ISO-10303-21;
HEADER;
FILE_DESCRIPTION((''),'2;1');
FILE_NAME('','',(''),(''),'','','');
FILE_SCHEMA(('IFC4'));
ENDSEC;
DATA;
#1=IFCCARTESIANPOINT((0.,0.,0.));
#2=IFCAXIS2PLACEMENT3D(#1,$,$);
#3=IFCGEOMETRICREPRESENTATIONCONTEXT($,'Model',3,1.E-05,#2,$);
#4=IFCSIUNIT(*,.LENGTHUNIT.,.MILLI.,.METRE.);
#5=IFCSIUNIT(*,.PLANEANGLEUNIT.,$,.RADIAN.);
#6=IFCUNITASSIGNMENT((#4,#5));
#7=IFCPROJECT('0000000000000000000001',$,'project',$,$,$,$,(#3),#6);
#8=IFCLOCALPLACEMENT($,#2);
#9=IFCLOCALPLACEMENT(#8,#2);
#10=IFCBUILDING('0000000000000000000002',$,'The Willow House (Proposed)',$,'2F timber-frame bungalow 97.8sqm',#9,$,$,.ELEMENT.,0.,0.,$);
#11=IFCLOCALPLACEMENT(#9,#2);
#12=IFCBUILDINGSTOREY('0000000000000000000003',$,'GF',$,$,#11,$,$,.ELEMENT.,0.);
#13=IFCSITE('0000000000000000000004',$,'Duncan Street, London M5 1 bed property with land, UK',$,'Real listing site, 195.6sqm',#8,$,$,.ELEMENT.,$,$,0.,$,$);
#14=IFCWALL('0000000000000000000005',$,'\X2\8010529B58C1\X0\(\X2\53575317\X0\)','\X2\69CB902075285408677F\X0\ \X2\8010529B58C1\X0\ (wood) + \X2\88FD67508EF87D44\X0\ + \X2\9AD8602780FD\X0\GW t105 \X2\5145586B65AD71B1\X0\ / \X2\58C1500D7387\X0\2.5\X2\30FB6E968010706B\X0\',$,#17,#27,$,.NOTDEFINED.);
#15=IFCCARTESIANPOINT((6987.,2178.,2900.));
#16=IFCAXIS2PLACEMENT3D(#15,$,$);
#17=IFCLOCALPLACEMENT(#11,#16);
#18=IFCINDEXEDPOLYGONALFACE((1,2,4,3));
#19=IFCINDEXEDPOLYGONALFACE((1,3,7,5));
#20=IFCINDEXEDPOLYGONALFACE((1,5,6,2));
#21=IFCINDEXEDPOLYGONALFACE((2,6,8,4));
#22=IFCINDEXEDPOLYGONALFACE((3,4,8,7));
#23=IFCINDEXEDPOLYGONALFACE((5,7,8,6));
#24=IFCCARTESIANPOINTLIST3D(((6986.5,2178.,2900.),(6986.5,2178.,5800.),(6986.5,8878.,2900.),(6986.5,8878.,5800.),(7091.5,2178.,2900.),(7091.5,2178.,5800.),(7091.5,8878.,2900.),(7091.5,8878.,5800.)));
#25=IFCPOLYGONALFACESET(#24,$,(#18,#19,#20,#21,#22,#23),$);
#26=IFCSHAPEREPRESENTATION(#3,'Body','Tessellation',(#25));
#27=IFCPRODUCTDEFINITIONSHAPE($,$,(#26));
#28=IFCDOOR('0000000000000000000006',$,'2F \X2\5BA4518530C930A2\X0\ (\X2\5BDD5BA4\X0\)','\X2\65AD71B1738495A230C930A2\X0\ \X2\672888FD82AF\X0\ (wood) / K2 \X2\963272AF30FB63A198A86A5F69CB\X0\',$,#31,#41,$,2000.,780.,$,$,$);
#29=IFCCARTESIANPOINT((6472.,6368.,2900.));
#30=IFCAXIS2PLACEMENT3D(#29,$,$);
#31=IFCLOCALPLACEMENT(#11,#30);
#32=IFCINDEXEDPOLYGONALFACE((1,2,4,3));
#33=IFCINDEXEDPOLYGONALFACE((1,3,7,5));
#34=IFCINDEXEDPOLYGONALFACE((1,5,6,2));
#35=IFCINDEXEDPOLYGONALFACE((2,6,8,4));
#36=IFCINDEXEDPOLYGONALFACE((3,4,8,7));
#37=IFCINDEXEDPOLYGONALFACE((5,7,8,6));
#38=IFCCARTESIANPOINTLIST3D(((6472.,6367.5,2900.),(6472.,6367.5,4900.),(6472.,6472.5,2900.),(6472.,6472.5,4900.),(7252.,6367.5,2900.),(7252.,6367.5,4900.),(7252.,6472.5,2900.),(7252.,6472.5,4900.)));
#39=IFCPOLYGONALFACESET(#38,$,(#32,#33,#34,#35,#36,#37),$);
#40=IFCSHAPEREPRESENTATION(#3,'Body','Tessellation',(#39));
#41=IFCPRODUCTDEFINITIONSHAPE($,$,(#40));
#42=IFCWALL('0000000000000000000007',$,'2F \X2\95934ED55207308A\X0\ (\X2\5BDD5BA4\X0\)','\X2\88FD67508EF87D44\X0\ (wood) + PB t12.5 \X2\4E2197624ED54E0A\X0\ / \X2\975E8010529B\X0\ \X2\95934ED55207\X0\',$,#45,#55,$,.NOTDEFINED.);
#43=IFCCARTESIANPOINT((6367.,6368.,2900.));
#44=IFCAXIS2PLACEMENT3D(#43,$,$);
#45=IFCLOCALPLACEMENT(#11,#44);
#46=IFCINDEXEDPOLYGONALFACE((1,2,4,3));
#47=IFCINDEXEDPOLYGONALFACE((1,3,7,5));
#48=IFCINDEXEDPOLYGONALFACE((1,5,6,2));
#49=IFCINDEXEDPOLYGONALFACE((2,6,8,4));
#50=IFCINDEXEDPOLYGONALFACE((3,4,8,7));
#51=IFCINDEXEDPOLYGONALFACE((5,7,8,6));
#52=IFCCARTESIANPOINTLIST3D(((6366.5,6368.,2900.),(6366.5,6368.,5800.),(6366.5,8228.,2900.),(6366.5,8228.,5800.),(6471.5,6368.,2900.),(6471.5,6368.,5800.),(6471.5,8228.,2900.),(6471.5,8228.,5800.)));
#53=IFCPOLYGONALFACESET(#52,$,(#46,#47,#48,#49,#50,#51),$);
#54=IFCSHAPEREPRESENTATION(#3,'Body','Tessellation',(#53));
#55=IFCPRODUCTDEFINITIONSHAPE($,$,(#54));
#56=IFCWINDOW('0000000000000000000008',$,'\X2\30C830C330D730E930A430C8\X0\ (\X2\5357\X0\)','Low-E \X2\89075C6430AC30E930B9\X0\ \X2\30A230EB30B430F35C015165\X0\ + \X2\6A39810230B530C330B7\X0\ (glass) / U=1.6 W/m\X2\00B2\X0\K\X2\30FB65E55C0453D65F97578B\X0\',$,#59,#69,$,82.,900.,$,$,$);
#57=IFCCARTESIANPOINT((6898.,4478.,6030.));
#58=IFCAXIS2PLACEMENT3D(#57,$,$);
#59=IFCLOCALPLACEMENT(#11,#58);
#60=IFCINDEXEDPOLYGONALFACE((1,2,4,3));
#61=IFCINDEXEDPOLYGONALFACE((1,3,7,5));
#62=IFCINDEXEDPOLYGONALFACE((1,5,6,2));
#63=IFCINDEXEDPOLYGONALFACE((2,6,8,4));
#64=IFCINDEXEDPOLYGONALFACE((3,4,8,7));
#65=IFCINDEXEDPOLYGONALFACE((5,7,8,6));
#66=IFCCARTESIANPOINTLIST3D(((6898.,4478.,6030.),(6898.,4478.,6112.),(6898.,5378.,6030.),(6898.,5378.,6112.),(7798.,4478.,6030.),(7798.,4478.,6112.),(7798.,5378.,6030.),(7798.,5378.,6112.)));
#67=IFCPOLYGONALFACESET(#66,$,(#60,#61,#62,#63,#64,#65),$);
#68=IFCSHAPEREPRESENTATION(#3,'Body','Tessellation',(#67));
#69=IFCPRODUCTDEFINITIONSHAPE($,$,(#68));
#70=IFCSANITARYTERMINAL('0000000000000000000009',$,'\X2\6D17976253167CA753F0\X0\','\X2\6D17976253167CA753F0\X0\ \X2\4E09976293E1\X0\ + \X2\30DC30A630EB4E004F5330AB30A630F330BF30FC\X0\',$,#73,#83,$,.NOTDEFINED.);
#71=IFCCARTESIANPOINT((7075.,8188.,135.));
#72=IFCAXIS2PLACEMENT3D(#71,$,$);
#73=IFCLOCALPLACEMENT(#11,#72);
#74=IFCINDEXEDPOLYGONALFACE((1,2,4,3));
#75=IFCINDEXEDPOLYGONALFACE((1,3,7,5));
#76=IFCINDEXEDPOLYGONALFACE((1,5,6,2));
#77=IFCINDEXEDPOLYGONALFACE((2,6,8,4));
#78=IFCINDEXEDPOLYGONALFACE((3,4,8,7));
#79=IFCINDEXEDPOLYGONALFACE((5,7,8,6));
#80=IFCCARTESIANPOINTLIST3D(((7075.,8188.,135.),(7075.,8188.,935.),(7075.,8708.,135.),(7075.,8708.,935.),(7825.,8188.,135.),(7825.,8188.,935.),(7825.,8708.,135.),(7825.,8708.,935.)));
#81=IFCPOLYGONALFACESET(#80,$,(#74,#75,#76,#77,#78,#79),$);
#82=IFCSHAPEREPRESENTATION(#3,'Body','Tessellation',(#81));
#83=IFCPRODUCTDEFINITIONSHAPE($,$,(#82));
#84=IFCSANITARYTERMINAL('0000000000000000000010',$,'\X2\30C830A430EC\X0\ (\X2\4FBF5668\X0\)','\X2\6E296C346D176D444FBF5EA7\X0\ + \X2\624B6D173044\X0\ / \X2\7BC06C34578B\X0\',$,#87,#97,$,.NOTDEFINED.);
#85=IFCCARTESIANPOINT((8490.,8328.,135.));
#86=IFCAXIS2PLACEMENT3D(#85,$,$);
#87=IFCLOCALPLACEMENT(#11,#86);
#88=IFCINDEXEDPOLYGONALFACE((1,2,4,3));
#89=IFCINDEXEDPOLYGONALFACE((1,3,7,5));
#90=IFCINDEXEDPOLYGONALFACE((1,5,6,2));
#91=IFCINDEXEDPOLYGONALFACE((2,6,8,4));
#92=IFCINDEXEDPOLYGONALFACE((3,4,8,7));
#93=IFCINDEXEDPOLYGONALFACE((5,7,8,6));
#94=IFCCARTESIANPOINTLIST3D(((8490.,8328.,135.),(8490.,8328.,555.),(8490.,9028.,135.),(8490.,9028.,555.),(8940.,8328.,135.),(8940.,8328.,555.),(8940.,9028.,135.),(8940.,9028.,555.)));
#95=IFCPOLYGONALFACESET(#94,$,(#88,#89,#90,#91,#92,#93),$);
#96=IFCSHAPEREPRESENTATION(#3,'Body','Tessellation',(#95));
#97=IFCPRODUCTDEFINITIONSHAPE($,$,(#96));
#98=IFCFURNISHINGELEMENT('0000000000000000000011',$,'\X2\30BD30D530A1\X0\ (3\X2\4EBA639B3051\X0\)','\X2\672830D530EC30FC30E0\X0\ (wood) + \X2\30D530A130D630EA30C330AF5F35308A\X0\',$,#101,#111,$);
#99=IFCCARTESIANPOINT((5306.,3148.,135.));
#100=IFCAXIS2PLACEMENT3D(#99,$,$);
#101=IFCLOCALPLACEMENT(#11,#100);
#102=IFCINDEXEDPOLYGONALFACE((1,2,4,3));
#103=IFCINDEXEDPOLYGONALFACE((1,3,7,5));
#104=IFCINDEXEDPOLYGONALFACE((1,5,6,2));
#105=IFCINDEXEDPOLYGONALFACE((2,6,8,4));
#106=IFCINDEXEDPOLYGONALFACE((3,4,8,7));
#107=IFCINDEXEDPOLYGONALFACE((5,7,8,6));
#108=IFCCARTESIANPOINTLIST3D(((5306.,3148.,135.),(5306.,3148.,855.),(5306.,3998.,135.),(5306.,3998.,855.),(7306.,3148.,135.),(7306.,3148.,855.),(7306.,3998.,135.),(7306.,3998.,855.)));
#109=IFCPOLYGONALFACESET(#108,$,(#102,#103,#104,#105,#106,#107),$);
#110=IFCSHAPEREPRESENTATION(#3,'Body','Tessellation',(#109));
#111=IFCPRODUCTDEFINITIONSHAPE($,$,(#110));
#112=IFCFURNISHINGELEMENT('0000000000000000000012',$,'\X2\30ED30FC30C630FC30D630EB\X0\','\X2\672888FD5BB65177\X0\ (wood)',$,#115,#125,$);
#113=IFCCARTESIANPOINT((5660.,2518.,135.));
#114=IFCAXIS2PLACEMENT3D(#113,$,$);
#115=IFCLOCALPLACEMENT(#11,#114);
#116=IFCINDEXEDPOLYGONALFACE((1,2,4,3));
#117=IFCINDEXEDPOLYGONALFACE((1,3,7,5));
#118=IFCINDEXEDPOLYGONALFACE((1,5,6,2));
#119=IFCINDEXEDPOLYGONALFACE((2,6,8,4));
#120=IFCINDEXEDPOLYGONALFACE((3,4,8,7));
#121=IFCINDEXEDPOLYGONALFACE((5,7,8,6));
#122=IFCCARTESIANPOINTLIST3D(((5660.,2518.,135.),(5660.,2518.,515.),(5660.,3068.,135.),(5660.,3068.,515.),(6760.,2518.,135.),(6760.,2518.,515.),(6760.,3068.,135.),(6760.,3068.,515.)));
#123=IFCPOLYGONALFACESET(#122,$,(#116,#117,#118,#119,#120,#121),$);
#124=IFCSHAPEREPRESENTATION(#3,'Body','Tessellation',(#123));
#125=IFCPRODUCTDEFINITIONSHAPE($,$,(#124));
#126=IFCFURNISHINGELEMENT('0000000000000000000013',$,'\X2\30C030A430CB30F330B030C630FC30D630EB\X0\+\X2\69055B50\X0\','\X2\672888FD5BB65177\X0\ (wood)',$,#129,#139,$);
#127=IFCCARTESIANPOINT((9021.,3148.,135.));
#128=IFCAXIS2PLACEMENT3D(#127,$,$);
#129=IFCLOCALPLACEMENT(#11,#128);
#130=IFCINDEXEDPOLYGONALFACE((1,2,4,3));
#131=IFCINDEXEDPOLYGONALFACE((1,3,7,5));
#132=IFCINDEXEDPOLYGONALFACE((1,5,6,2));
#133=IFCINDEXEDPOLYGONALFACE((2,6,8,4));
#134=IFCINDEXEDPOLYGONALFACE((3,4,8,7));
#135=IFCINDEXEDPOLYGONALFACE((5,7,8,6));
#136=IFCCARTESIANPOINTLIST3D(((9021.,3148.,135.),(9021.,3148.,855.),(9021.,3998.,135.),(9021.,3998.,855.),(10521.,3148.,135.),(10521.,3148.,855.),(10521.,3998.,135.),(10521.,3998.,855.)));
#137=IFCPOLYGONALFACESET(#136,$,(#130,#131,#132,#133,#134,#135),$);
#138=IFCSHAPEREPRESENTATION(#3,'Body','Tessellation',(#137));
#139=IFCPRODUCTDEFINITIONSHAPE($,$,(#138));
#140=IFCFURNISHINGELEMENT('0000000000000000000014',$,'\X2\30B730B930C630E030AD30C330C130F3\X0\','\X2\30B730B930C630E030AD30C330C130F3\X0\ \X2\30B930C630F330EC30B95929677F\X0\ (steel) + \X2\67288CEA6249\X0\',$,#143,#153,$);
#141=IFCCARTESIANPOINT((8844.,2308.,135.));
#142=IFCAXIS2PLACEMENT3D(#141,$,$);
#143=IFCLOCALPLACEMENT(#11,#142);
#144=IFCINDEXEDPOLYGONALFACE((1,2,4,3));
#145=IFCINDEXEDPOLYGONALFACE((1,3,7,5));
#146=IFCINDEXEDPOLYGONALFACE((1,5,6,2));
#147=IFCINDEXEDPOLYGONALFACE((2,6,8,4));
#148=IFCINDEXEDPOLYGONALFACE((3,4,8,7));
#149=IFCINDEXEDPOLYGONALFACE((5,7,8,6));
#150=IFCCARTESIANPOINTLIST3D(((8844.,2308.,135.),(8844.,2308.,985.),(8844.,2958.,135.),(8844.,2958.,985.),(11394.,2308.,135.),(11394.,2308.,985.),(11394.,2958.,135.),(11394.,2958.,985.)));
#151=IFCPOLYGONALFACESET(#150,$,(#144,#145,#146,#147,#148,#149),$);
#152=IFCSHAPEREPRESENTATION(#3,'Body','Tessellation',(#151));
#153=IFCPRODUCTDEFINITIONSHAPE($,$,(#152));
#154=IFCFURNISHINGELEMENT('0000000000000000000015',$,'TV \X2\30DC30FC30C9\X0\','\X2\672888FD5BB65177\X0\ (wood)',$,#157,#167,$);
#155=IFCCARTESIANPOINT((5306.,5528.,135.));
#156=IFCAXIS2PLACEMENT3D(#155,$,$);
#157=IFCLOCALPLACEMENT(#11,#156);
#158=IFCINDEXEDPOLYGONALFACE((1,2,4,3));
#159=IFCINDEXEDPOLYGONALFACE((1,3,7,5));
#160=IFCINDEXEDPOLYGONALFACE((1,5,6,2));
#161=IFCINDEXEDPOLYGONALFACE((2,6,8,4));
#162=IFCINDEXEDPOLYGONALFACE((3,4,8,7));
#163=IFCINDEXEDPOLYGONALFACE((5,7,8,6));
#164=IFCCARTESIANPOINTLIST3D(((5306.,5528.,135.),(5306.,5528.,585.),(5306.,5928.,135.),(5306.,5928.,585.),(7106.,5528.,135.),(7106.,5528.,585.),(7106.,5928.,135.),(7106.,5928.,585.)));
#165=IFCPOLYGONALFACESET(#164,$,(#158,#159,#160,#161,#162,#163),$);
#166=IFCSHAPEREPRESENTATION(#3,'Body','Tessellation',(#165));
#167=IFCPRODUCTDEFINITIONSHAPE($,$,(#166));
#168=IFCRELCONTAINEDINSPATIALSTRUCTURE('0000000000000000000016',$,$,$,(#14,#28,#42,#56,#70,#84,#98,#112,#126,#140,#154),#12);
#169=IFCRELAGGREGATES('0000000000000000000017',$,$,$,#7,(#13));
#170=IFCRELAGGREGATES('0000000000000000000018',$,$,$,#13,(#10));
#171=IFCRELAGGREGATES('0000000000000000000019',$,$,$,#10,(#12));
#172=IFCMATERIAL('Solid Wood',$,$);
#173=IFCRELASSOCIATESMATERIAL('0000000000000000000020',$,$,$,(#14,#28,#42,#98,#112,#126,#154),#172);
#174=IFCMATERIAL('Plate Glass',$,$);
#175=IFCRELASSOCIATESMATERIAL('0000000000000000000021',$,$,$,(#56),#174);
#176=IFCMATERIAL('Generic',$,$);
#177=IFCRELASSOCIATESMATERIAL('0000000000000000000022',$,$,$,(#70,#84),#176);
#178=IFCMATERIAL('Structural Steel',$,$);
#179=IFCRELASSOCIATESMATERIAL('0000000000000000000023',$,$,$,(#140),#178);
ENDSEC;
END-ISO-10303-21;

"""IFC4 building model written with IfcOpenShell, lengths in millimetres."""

from ifc_helpers import new_model, si_unit, frame, frame_2d, origin, place, context, project, spatial, rectangle, extrude, material, element, fill, save


model = new_model("IFC4")

# Units and contexts
model_context = context("Model", 3, precision=1e-05, world=origin())
ifc_project = project(units=[si_unit("LENGTHUNIT", "METRE", prefix="MILLI"), si_unit("PLANEANGLEUNIT", "RADIAN")], contexts=[model_context])

# Site, building, storey
site_placement = place(None, origin())
site = spatial("IfcSite", under=ifc_project, at=site_placement, Name="Duncan Street, London M5 1 bed property with land, UK", ObjectType="Real listing site, 195.6sqm", CompositionType="ELEMENT", RefElevation=0.0)
building_placement = place(site_placement, origin())
building = spatial("IfcBuilding", under=site, at=building_placement, Name="The Willow House (Proposed)", ObjectType="2F timber-frame bungalow 97.8sqm", CompositionType="ELEMENT", ElevationOfRefHeight=0.0, ElevationOfTerrain=0.0)
storey_placement = place(building_placement, origin())
storey = spatial("IfcBuildingStorey", under=building, at=storey_placement, Name="GF", CompositionType="ELEMENT", Elevation=0.0)

# Shared definitions
ifc_material_1 = material(Name="Solid Wood")

# Wall, opening, door
wall_1_placement = place(storey_placement, frame((6987.0, 2178.0, 2900.0)))
wall_1 = element("IfcWall", 1, at=wall_1_placement, inside=storey, material=ifc_material_1, Name="耐力壁(南北)", Description="構造用合板 耐力壁 (wood) + 製材軸組 + 高性能GW t105 充填断熱 / 壁倍率2.5・準耐火", PredefinedType="NOTDEFINED", context=model_context, shape_type="SweptSolid", body=[
    extrude(rectangle(XDim=105.0, YDim=6700.0, at=frame_2d((52.0, 3350.0))), frame((6987.0, 2178.0, 2900.0)), (0.0, 0.0, 1.0), 2900.0),
])
opening_1_placement = place(storey_placement, frame((6472.0, 6368.0, 2900.0)))
opening_1 = element("IfcOpeningElement", 2, at=opening_1_placement, cuts=wall_1, PredefinedType="NOTDEFINED", context=model_context, shape_type="SweptSolid", body=[
    extrude(rectangle(XDim=780.0, YDim=105.0, at=frame_2d((390.0, 52.0))), frame((6472.0, 6368.0, 2900.0)), (0.0, 0.0, 1.0), 2000.0),
])
door_1_placement = place(storey_placement, frame((6472.0, 6368.0, 2900.0)))
door_1 = element("IfcDoor", 3, at=door_1_placement, inside=storey, material=ifc_material_1, Name="2F 室内ドア (寝室)", Description="断熱玄関ドア 木製芯 (wood) / K2 防犯・採風機構", OverallHeight=2000.0, OverallWidth=780.0, context=model_context, shape_type="SweptSolid", body=[
    extrude(rectangle(XDim=780.0, YDim=105.0, at=frame_2d((390.0, 52.0))), frame((6472.0, 6368.0, 2900.0)), (0.0, 0.0, 1.0), 2000.0),
])
fill(opening_1, door_1)

# Wall
wall_2_placement = place(storey_placement, frame((6367.0, 6368.0, 2900.0)))
element("IfcWall", 4, at=wall_2_placement, inside=storey, material=ifc_material_1, Name="2F 間仕切り (寝室)", Description="製材軸組 (wood) + PB t12.5 両面仕上 / 非耐力 間仕切", PredefinedType="NOTDEFINED", context=model_context, shape_type="SweptSolid", body=[
    extrude(rectangle(XDim=105.0, YDim=1860.0, at=frame_2d((52.0, 930.0))), frame((6367.0, 6368.0, 2900.0)), (0.0, 0.0, 1.0), 2900.0),
])

# Window
ifc_material_2 = material(Name="Plate Glass")
window_placement = place(storey_placement, frame((6898.0, 4478.0, 6030.0)))
element("IfcWindow", 5, at=window_placement, inside=storey, material=ifc_material_2, Name="トップライト (南)", Description="Low-E 複層ガラス アルゴン封入 + 樹脂サッシ (glass) / U=1.6 W/m²K・日射取得型", OverallHeight=82.0, OverallWidth=900.0, context=model_context, shape_type="SweptSolid", body=[
    extrude(rectangle(XDim=900.0, YDim=900.0, at=frame_2d((450.0, 450.0))), frame((6898.0, 4478.0, 6030.0)), (0.0, 0.0, 1.0), 82.0),
])

# Sanitary terminals
ifc_material_3 = material(Name="Generic")
sanitary_terminal_1_placement = place(storey_placement, frame((7075.0, 8188.0, 135.0)))
element("IfcSanitaryTerminal", 6, at=sanitary_terminal_1_placement, inside=storey, material=ifc_material_3, Name="洗面化粧台", Description="洗面化粧台 三面鏡 + ボウル一体カウンター", PredefinedType="NOTDEFINED", context=model_context, shape_type="SweptSolid", body=[
    extrude(rectangle(XDim=750.0, YDim=520.0, at=frame_2d((375.0, 260.0))), frame((7075.0, 8188.0, 135.0)), (0.0, 0.0, 1.0), 800.0),
])
sanitary_terminal_2_placement = place(storey_placement, frame((8490.0, 8328.0, 135.0)))
element("IfcSanitaryTerminal", 7, at=sanitary_terminal_2_placement, inside=storey, material=ifc_material_3, Name="トイレ (便器)", Description="温水洗浄便座 + 手洗い / 節水型", PredefinedType="NOTDEFINED", context=model_context, shape_type="SweptSolid", body=[
    extrude(rectangle(XDim=450.0, YDim=700.0, at=frame_2d((225.0, 350.0))), frame((8490.0, 8328.0, 135.0)), (0.0, 0.0, 1.0), 420.0),
])

# Furnishing elements
furnishing_1_placement = place(storey_placement, frame((5306.0, 3148.0, 135.0)))
element("IfcFurnishingElement", 8, at=furnishing_1_placement, inside=storey, material=ifc_material_1, Name="ソファ (3人掛け)", Description="木フレーム (wood) + ファブリック張り", context=model_context, shape_type="SweptSolid", body=[
    extrude(rectangle(XDim=2000.0, YDim=850.0, at=frame_2d((1000.0, 425.0))), frame((5306.0, 3148.0, 135.0)), (0.0, 0.0, 1.0), 720.0),
])
furnishing_2_placement = place(storey_placement, frame((5660.0, 2518.0, 135.0)))
element("IfcFurnishingElement", 9, at=furnishing_2_placement, inside=storey, material=ifc_material_1, Name="ローテーブル", Description="木製家具 (wood)", context=model_context, shape_type="SweptSolid", body=[
    extrude(rectangle(XDim=1100.0, YDim=550.0, at=frame_2d((550.0, 275.0))), frame((5660.0, 2518.0, 135.0)), (0.0, 0.0, 1.0), 380.0),
])
furnishing_3_placement = place(storey_placement, frame((9021.0, 3148.0, 135.0)))
element("IfcFurnishingElement", 10, at=furnishing_3_placement, inside=storey, material=ifc_material_1, Name="ダイニングテーブル+椅子", Description="木製家具 (wood)", context=model_context, shape_type="SweptSolid", body=[
    extrude(rectangle(XDim=1500.0, YDim=850.0, at=frame_2d((750.0, 425.0))), frame((9021.0, 3148.0, 135.0)), (0.0, 0.0, 1.0), 720.0),
])
ifc_material_4 = material(Name="Structural Steel")
furnishing_4_placement = place(storey_placement, frame((8844.0, 2308.0, 135.0)))
element("IfcFurnishingElement", 11, at=furnishing_4_placement, inside=storey, material=ifc_material_4, Name="システムキッチン", Description="システムキッチン ステンレス天板 (steel) + 木質扉", context=model_context, shape_type="SweptSolid", body=[
    extrude(rectangle(XDim=2550.0, YDim=650.0, at=frame_2d((1275.0, 325.0))), frame((8844.0, 2308.0, 135.0)), (0.0, 0.0, 1.0), 850.0),
])
furnishing_5_placement = place(storey_placement, frame((5306.0, 5528.0, 135.0)))
element("IfcFurnishingElement", 12, at=furnishing_5_placement, inside=storey, material=ifc_material_1, Name="TV ボード", Description="木製家具 (wood)", context=model_context, shape_type="SweptSolid", body=[
    extrude(rectangle(XDim=1800.0, YDim=400.0, at=frame_2d((900.0, 200.0))), frame((5306.0, 5528.0, 135.0)), (0.0, 0.0, 1.0), 450.0),
])

save(model, "model.ifc")
